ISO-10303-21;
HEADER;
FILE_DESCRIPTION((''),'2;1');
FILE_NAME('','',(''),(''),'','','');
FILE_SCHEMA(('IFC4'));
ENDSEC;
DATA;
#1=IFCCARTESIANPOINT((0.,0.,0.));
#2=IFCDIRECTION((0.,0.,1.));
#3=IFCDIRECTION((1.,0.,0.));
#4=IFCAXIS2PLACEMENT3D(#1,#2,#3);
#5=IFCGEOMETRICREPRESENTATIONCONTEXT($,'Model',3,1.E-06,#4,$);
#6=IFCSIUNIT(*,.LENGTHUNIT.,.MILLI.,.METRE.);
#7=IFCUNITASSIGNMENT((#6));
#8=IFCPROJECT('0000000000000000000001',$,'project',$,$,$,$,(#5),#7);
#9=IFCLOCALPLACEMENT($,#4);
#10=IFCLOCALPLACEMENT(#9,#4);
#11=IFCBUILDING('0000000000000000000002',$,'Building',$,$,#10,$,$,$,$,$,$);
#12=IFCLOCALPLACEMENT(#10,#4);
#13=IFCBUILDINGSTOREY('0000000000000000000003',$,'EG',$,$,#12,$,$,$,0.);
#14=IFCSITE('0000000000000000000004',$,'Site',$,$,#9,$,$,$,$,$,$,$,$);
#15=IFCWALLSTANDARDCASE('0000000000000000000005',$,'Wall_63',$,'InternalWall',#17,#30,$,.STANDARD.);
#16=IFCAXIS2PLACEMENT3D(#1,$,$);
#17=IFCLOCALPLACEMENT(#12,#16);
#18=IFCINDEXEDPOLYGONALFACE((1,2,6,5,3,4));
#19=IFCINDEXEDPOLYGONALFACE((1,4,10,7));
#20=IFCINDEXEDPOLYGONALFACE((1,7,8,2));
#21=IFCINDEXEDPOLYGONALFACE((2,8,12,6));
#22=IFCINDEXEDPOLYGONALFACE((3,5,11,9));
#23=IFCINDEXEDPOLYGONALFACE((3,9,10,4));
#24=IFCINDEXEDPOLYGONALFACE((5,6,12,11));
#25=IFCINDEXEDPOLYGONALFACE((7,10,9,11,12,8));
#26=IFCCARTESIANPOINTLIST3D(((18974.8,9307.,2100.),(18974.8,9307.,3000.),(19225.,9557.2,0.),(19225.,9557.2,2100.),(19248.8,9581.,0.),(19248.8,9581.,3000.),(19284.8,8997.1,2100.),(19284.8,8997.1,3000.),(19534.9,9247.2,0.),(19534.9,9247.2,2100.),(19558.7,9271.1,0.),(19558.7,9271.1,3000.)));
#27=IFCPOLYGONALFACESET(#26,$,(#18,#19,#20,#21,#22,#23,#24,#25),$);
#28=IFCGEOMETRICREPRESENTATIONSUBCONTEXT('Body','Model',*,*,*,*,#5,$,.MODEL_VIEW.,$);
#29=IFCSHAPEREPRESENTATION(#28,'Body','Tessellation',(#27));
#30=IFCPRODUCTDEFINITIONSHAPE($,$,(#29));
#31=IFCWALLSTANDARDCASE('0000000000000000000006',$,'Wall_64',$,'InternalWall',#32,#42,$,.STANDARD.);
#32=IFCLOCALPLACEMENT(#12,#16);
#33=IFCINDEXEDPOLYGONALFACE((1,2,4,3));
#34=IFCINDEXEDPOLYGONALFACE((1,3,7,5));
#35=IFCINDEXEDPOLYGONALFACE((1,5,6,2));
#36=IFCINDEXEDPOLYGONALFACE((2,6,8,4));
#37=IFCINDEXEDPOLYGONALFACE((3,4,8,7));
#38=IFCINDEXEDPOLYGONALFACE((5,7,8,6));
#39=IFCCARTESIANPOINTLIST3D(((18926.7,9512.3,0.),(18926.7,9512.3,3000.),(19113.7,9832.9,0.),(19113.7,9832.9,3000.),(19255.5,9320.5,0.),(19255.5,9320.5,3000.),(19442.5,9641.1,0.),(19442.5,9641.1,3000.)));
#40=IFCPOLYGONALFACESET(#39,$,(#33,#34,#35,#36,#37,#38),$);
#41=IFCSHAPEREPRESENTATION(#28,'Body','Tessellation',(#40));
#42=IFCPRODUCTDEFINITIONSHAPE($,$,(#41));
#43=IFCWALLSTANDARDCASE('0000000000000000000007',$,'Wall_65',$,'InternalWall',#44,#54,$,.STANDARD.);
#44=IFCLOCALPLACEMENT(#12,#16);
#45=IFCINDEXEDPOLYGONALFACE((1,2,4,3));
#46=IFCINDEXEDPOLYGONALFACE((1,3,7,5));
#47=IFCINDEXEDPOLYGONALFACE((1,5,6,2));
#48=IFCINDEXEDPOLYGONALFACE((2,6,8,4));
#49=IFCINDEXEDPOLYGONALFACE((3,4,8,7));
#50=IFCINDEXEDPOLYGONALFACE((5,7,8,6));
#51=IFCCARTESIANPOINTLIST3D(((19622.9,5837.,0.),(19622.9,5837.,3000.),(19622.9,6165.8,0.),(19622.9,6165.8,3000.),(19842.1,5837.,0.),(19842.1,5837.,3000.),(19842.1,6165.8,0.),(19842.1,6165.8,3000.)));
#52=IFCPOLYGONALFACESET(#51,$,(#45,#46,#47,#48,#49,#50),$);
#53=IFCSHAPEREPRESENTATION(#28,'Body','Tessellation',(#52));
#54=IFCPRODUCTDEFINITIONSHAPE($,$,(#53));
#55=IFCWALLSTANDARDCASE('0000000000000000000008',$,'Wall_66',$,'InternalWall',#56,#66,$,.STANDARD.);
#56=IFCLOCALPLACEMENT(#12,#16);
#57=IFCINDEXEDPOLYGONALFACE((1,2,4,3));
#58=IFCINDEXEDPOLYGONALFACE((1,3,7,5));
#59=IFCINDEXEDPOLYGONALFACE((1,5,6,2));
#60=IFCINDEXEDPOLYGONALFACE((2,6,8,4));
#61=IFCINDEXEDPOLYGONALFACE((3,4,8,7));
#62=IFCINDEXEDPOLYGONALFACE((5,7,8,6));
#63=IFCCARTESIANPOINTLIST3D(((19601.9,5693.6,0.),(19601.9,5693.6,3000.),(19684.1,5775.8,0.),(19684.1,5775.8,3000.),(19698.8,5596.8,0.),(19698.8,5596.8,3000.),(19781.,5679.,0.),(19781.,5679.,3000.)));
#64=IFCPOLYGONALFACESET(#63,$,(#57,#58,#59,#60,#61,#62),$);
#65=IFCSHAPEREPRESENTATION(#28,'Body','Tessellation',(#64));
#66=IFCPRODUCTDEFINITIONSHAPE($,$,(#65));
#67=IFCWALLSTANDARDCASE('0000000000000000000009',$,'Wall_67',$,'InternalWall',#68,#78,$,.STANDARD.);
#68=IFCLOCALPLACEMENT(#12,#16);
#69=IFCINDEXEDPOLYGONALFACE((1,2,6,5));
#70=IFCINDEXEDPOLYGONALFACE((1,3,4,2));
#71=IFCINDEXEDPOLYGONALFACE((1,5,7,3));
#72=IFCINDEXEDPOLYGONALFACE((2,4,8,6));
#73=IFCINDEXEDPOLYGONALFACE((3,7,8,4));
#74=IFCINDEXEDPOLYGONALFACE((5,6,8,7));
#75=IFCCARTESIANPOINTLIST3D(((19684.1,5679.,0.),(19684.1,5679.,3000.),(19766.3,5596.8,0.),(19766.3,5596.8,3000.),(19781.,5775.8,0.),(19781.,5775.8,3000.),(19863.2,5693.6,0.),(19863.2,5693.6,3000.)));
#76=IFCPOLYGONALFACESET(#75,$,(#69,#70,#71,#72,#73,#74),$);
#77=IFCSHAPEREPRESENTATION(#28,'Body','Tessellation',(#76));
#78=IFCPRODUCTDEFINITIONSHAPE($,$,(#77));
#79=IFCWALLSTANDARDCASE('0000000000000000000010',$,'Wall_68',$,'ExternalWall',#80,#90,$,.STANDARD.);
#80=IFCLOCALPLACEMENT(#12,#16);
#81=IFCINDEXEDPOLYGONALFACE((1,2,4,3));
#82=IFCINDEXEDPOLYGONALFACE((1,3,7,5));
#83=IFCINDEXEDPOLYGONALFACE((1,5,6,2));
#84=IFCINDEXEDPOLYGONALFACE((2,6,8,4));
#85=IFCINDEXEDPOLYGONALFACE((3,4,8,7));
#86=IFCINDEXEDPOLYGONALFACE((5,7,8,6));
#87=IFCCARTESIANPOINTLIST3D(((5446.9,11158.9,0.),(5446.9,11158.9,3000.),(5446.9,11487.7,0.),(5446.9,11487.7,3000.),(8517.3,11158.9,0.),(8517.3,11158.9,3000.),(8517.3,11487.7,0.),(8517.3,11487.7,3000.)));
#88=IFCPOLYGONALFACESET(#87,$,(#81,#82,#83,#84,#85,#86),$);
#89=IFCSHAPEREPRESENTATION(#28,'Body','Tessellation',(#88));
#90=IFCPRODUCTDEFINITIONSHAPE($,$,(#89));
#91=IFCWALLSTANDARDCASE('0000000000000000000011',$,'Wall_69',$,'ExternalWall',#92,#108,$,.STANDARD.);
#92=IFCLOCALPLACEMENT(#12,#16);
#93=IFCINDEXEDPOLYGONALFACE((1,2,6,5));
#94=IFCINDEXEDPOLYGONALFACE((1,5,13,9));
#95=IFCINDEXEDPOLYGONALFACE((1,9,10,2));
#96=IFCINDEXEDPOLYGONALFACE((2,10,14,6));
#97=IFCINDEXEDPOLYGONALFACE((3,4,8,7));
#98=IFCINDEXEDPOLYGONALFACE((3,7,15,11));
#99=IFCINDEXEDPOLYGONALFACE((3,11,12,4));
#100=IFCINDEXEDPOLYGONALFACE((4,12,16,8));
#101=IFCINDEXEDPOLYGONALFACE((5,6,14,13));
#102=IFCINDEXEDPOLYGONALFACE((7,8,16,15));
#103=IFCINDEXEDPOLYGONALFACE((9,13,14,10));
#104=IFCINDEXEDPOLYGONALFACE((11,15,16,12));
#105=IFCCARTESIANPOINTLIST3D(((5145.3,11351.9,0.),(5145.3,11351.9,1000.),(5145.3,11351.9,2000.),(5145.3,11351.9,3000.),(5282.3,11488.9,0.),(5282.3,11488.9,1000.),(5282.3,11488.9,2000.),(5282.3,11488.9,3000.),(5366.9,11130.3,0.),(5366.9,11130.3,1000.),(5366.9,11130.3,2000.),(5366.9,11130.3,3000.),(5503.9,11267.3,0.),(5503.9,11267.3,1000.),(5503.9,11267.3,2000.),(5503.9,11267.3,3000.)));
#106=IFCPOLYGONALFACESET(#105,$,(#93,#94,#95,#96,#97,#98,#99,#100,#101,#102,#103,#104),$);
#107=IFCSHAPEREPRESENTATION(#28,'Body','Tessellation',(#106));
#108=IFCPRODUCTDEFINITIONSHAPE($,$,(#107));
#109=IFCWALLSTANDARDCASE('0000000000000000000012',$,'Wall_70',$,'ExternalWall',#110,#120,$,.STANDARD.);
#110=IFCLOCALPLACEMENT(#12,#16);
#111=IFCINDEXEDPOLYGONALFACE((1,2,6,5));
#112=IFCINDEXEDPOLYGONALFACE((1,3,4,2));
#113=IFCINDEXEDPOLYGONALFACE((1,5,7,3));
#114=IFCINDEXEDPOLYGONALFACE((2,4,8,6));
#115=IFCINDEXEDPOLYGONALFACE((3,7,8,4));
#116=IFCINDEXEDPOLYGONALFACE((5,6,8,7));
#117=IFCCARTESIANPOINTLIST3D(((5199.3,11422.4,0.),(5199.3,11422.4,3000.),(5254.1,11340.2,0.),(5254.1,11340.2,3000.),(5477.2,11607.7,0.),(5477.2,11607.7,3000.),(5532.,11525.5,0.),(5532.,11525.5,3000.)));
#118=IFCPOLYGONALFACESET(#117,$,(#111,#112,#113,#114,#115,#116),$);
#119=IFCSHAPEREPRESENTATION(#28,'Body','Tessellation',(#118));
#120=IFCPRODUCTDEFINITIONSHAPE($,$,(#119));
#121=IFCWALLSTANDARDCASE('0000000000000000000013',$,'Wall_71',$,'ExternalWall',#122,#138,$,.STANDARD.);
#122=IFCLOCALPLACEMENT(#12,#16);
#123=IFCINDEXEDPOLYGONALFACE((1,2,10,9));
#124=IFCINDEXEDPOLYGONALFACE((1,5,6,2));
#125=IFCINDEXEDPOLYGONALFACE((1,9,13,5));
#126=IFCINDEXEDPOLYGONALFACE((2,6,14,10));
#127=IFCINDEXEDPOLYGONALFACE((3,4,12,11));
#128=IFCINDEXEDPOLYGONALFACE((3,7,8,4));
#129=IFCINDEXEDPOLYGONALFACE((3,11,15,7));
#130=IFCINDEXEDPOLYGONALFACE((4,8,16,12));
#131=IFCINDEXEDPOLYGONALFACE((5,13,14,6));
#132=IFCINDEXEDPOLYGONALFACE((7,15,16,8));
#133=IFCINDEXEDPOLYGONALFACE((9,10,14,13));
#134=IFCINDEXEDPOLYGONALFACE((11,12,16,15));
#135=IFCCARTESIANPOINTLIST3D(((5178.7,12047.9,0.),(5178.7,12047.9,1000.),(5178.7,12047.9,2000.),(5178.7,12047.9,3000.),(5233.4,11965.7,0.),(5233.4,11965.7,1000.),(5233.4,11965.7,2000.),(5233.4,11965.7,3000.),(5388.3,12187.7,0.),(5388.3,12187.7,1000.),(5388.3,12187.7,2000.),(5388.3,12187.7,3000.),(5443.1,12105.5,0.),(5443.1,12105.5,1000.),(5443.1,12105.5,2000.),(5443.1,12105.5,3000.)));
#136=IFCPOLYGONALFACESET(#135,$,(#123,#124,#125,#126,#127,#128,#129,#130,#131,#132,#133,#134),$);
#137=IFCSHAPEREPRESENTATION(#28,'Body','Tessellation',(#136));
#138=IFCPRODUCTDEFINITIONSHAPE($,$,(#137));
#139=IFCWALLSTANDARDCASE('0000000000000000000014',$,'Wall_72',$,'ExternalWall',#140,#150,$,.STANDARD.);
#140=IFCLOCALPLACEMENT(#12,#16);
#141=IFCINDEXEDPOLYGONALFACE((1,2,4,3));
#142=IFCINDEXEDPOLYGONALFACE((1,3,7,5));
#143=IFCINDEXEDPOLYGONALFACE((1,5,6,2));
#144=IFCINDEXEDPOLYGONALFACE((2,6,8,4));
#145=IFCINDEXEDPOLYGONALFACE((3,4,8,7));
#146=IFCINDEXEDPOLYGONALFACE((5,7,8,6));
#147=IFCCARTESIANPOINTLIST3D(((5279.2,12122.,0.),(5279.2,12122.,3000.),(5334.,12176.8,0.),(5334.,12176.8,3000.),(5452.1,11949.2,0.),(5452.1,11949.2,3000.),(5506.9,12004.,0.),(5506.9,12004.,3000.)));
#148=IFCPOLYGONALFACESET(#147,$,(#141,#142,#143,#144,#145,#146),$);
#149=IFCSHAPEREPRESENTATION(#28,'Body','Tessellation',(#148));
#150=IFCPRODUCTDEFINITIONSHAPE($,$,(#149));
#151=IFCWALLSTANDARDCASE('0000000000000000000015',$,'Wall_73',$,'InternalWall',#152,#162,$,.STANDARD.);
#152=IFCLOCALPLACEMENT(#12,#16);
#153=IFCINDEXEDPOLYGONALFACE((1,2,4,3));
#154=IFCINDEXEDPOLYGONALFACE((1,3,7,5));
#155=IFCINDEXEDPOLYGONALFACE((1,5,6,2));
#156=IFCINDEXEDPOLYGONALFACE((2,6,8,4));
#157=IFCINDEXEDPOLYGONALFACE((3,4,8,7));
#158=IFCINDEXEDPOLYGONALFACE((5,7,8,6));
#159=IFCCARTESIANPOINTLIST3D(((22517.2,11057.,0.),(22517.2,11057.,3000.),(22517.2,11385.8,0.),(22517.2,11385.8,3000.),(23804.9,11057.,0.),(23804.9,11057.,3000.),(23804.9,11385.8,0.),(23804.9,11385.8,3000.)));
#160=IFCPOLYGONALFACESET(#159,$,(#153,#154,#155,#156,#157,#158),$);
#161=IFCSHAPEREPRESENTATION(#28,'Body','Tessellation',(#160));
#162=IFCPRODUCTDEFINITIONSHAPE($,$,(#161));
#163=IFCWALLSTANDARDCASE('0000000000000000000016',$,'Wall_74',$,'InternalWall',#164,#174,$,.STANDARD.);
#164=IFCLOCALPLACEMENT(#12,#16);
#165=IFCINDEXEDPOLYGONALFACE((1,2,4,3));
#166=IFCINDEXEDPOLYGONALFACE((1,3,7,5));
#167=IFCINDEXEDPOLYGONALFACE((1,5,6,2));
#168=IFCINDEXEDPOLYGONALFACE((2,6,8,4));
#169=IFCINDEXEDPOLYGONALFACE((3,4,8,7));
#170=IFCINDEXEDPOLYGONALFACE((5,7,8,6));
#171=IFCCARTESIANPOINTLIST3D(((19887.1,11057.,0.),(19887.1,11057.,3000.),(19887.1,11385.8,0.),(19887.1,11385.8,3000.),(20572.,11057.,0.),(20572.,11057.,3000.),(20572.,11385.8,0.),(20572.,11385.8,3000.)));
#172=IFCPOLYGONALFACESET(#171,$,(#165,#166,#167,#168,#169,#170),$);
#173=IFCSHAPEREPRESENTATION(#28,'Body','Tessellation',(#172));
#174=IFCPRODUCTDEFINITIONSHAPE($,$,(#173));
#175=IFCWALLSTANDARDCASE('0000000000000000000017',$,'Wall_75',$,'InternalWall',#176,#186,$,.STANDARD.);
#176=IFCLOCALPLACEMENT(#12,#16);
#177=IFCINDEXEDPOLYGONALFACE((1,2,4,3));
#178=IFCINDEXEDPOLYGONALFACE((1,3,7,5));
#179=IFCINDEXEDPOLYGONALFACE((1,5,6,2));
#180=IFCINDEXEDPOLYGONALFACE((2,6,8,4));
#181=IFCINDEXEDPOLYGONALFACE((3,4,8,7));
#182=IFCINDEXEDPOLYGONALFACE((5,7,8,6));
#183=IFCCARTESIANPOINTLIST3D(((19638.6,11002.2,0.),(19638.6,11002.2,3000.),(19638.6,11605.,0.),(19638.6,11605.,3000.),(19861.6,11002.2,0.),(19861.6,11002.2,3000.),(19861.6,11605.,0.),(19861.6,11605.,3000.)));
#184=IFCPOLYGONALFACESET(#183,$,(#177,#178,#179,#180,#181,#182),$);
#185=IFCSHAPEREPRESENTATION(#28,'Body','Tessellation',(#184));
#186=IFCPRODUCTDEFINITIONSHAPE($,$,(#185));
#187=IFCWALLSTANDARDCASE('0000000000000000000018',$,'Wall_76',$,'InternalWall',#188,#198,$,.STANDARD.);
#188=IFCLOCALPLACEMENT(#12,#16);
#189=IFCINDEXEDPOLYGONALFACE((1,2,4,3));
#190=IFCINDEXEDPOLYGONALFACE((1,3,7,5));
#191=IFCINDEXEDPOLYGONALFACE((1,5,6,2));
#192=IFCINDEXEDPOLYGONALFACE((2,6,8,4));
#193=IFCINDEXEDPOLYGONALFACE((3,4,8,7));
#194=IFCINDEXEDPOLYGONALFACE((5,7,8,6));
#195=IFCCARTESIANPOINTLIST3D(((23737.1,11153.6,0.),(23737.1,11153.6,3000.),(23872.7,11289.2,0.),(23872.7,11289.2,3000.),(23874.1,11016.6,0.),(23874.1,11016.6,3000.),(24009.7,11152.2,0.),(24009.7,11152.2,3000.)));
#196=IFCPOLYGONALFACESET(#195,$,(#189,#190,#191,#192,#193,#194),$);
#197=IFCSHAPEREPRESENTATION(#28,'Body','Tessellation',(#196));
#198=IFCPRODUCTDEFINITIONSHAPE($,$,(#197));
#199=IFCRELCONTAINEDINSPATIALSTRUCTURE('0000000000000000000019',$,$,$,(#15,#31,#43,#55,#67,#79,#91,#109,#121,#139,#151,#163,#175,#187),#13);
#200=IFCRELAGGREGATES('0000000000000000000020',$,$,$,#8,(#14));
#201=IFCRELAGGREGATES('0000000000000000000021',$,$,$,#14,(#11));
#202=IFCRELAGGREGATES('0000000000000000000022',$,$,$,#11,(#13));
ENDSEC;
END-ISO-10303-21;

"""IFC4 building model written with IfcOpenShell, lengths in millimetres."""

from ifc_helpers import new_model, si_unit, frame, origin_with_axes, place, context, subcontext, project, spatial, rectangle, extrude, element, save


model = new_model("IFC4")

# Units and contexts
model_context = context("Model", 3, precision=1e-06, world=origin_with_axes())
body_context = subcontext(model_context, "Body", "Model", "MODEL_VIEW")
ifc_project = project(units=[si_unit("LENGTHUNIT", "METRE", prefix="MILLI")], contexts=[model_context])

# Site, building, storey
site_placement = place(None, origin_with_axes())
site = spatial("IfcSite", under=ifc_project, at=site_placement, Name="Site")
building_placement = place(site_placement, origin_with_axes())
building = spatial("IfcBuilding", under=site, at=building_placement, Name="Building")
storey_placement = place(building_placement, origin_with_axes())
storey = spatial("IfcBuildingStorey", under=building, at=storey_placement, Name="EG", Elevation=0.0)

# Wall, opening
wall_1_placement = place(storey_placement, origin_with_axes())
wall_1 = element("IfcWallStandardCase", 1, at=wall_1_placement, inside=storey, Name="Wall_63", ObjectType="InternalWall", PredefinedType="STANDARD", context=body_context, shape_type="SweptSolid", body=[
    extrude(rectangle(XDim=387.5, YDim=438.3), frame((19266.8, 9289.0, 0.0), z_axis=(0.0, 0.0, 1.0), x_axis=(-0.707107, -0.707107, 0.0)), (0.0, 0.0, 1.0), 3000.0),
])
opening_1_placement = place(wall_1_placement, origin_with_axes())
element("IfcOpeningElement", 2, at=opening_1_placement, inside=storey, cuts=wall_1, context=body_context, shape_type="SweptSolid", body=[
    extrude(rectangle(XDim=450.0, YDim=438.3), frame((19220.8, 9243.1, 0.0), z_axis=(0.0, 0.0, 1.0), x_axis=(-0.707107, -0.707107, 0.0)), (0.0, 0.0, 1.0), 2100.0),
])

# Walls
wall_2_placement = place(storey_placement, origin_with_axes())
element("IfcWallStandardCase", 3, at=wall_2_placement, inside=storey, Name="Wall_64", ObjectType="InternalWall", PredefinedType="STANDARD", context=body_context, shape_type="SweptSolid", body=[
    extrude(rectangle(XDim=380.6, YDim=371.2), frame((19184.6, 9576.7, 0.0), z_axis=(0.0, 0.0, 1.0), x_axis=(-0.863779, 0.503871, 0.0)), (0.0, 0.0, 1.0), 3000.0),
])
wall_3_placement = place(storey_placement, origin_with_axes())
element("IfcWallStandardCase", 4, at=wall_3_placement, inside=storey, Name="Wall_65", ObjectType="InternalWall", PredefinedType="STANDARD", context=body_context, shape_type="SweptSolid", body=[
    extrude(rectangle(XDim=328.8, YDim=219.2), frame((19732.5, 6001.4, 0.0), z_axis=(0.0, 0.0, 1.0), x_axis=(0.0, -1.0, 0.0)), (0.0, 0.0, 1.0), 3000.0),
])
wall_4_placement = place(storey_placement, origin_with_axes())
element("IfcWallStandardCase", 5, at=wall_4_placement, inside=storey, Name="Wall_66", ObjectType="InternalWall", PredefinedType="STANDARD", context=body_context, shape_type="SweptSolid", body=[
    extrude(rectangle(XDim=116.2, YDim=137.0), frame((19691.4, 5686.3, 0.0), z_axis=(0.0, 0.0, 1.0), x_axis=(-0.707107, -0.707107, 0.0)), (0.0, 0.0, 1.0), 3000.0),
])
wall_5_placement = place(storey_placement, origin_with_axes())
element("IfcWallStandardCase", 6, at=wall_5_placement, inside=storey, Name="Wall_67", ObjectType="InternalWall", PredefinedType="STANDARD", context=body_context, shape_type="SweptSolid", body=[
    extrude(rectangle(XDim=116.2, YDim=137.0), frame((19773.6, 5686.3, 0.0), z_axis=(0.0, 0.0, 1.0), x_axis=(0.707107, -0.707107, 0.0)), (0.0, 0.0, 1.0), 3000.0),
])
wall_6_placement = place(storey_placement, origin_with_axes())
element("IfcWallStandardCase", 7, at=wall_6_placement, inside=storey, Name="Wall_68", ObjectType="ExternalWall", PredefinedType="STANDARD", context=body_context, shape_type="SweptSolid", body=[
    extrude(rectangle(XDim=3070.4, YDim=328.8), frame((6982.1, 11323.3, 0.0), z_axis=(0.0, 0.0, 1.0), x_axis=(1.0, 0.0, 0.0)), (0.0, 0.0, 1.0), 3000.0),
])

# Wall, opening
wall_7_placement = place(storey_placement, origin_with_axes())
wall_7 = element("IfcWallStandardCase", 8, at=wall_7_placement, inside=storey, Name="Wall_69", ObjectType="ExternalWall", PredefinedType="STANDARD", context=body_context, shape_type="SweptSolid", body=[
    extrude(rectangle(XDim=193.7, YDim=313.4), frame((5324.6, 11309.6, 0.0), z_axis=(0.0, 0.0, 1.0), x_axis=(-0.707107, -0.707107, 0.0)), (0.0, 0.0, 1.0), 3000.0),
])
opening_2_placement = place(wall_7_placement, origin_with_axes())
element("IfcOpeningElement", 9, at=opening_2_placement, inside=storey, cuts=wall_7, context=body_context, shape_type="SweptSolid", body=[
    extrude(rectangle(XDim=600.0, YDim=313.4), frame((5270.7, 11255.7, 1000.0), z_axis=(0.0, 0.0, 1.0), x_axis=(-0.707107, -0.707107, 0.0)), (0.0, 0.0, 1.0), 1000.0),
])

# Wall
wall_8_placement = place(storey_placement, origin_with_axes())
element("IfcWallStandardCase", 10, at=wall_8_placement, inside=storey, Name="Wall_70", ObjectType="ExternalWall", PredefinedType="STANDARD", context=body_context, shape_type="SweptSolid", body=[
    extrude(rectangle(XDim=98.8, YDim=334.0), frame((5365.7, 11474.0, 0.0), z_axis=(0.0, 0.0, 1.0), x_axis=(0.5547, -0.83205, 0.0)), (0.0, 0.0, 1.0), 3000.0),
])

# Wall, opening
wall_9_placement = place(storey_placement, origin_with_axes())
wall_9 = element("IfcWallStandardCase", 11, at=wall_9_placement, inside=storey, Name="Wall_71", ObjectType="ExternalWall", PredefinedType="STANDARD", context=body_context, shape_type="SweptSolid", body=[
    extrude(rectangle(XDim=98.8, YDim=252.0), frame((5310.9, 12076.7, 0.0), z_axis=(0.0, 0.0, 1.0), x_axis=(-0.5547, 0.83205, 0.0)), (0.0, 0.0, 1.0), 3000.0),
])
opening_3_placement = place(wall_9_placement, origin_with_axes())
element("IfcOpeningElement", 12, at=opening_3_placement, inside=storey, cuts=wall_9, context=body_context, shape_type="SweptSolid", body=[
    extrude(rectangle(XDim=600.0, YDim=252.0), frame((5296.5, 12098.2, 1000.0), z_axis=(0.0, 0.0, 1.0), x_axis=(-0.5547, 0.83205, 0.0)), (0.0, 0.0, 1.0), 1000.0),
])

# Walls
wall_10_placement = place(storey_placement, origin_with_axes())
element("IfcWallStandardCase", 13, at=wall_10_placement, inside=storey, Name="Wall_72", ObjectType="ExternalWall", PredefinedType="STANDARD", context=body_context, shape_type="SweptSolid", body=[
    extrude(rectangle(XDim=77.5, YDim=244.5), frame((5393.1, 12063.0, 0.0), z_axis=(0.0, 0.0, 1.0), x_axis=(0.707107, 0.707107, 0.0)), (0.0, 0.0, 1.0), 3000.0),
])
wall_11_placement = place(storey_placement, origin_with_axes())
element("IfcWallStandardCase", 14, at=wall_11_placement, inside=storey, Name="Wall_73", ObjectType="InternalWall", PredefinedType="STANDARD", context=body_context, shape_type="SweptSolid", body=[
    extrude(rectangle(XDim=1287.7, YDim=328.8), frame((23161.0, 11221.4, 0.0), z_axis=(0.0, 0.0, 1.0), x_axis=(-1.0, 0.0, 0.0)), (0.0, 0.0, 1.0), 3000.0),
])
wall_12_placement = place(storey_placement, origin_with_axes())
element("IfcWallStandardCase", 15, at=wall_12_placement, inside=storey, Name="Wall_74", ObjectType="InternalWall", PredefinedType="STANDARD", context=body_context, shape_type="SweptSolid", body=[
    extrude(rectangle(XDim=684.9, YDim=328.8), frame((20229.5, 11221.4, 0.0), z_axis=(0.0, 0.0, 1.0), x_axis=(-1.0, 0.0, 0.0)), (0.0, 0.0, 1.0), 3000.0),
])
wall_13_placement = place(storey_placement, origin_with_axes())
element("IfcWallStandardCase", 16, at=wall_13_placement, inside=storey, Name="Wall_75", ObjectType="InternalWall", PredefinedType="STANDARD", context=body_context, shape_type="SweptSolid", body=[
    extrude(rectangle(XDim=602.7, YDim=223.0), frame((19750.1, 11303.6, 0.0), z_axis=(0.0, 0.0, 1.0), x_axis=(0.0, -1.0, 0.0)), (0.0, 0.0, 1.0), 3000.0),
])
wall_14_placement = place(storey_placement, origin_with_axes())
element("IfcWallStandardCase", 17, at=wall_14_placement, inside=storey, Name="Wall_76", ObjectType="InternalWall", PredefinedType="STANDARD", context=body_context, shape_type="SweptSolid", body=[
    extrude(rectangle(XDim=193.7, YDim=191.8), frame((23873.4, 11152.9, 0.0), z_axis=(0.0, 0.0, 1.0), x_axis=(0.707107, -0.707107, 0.0)), (0.0, 0.0, 1.0), 3000.0),
])

save(model, "model.ifc")
